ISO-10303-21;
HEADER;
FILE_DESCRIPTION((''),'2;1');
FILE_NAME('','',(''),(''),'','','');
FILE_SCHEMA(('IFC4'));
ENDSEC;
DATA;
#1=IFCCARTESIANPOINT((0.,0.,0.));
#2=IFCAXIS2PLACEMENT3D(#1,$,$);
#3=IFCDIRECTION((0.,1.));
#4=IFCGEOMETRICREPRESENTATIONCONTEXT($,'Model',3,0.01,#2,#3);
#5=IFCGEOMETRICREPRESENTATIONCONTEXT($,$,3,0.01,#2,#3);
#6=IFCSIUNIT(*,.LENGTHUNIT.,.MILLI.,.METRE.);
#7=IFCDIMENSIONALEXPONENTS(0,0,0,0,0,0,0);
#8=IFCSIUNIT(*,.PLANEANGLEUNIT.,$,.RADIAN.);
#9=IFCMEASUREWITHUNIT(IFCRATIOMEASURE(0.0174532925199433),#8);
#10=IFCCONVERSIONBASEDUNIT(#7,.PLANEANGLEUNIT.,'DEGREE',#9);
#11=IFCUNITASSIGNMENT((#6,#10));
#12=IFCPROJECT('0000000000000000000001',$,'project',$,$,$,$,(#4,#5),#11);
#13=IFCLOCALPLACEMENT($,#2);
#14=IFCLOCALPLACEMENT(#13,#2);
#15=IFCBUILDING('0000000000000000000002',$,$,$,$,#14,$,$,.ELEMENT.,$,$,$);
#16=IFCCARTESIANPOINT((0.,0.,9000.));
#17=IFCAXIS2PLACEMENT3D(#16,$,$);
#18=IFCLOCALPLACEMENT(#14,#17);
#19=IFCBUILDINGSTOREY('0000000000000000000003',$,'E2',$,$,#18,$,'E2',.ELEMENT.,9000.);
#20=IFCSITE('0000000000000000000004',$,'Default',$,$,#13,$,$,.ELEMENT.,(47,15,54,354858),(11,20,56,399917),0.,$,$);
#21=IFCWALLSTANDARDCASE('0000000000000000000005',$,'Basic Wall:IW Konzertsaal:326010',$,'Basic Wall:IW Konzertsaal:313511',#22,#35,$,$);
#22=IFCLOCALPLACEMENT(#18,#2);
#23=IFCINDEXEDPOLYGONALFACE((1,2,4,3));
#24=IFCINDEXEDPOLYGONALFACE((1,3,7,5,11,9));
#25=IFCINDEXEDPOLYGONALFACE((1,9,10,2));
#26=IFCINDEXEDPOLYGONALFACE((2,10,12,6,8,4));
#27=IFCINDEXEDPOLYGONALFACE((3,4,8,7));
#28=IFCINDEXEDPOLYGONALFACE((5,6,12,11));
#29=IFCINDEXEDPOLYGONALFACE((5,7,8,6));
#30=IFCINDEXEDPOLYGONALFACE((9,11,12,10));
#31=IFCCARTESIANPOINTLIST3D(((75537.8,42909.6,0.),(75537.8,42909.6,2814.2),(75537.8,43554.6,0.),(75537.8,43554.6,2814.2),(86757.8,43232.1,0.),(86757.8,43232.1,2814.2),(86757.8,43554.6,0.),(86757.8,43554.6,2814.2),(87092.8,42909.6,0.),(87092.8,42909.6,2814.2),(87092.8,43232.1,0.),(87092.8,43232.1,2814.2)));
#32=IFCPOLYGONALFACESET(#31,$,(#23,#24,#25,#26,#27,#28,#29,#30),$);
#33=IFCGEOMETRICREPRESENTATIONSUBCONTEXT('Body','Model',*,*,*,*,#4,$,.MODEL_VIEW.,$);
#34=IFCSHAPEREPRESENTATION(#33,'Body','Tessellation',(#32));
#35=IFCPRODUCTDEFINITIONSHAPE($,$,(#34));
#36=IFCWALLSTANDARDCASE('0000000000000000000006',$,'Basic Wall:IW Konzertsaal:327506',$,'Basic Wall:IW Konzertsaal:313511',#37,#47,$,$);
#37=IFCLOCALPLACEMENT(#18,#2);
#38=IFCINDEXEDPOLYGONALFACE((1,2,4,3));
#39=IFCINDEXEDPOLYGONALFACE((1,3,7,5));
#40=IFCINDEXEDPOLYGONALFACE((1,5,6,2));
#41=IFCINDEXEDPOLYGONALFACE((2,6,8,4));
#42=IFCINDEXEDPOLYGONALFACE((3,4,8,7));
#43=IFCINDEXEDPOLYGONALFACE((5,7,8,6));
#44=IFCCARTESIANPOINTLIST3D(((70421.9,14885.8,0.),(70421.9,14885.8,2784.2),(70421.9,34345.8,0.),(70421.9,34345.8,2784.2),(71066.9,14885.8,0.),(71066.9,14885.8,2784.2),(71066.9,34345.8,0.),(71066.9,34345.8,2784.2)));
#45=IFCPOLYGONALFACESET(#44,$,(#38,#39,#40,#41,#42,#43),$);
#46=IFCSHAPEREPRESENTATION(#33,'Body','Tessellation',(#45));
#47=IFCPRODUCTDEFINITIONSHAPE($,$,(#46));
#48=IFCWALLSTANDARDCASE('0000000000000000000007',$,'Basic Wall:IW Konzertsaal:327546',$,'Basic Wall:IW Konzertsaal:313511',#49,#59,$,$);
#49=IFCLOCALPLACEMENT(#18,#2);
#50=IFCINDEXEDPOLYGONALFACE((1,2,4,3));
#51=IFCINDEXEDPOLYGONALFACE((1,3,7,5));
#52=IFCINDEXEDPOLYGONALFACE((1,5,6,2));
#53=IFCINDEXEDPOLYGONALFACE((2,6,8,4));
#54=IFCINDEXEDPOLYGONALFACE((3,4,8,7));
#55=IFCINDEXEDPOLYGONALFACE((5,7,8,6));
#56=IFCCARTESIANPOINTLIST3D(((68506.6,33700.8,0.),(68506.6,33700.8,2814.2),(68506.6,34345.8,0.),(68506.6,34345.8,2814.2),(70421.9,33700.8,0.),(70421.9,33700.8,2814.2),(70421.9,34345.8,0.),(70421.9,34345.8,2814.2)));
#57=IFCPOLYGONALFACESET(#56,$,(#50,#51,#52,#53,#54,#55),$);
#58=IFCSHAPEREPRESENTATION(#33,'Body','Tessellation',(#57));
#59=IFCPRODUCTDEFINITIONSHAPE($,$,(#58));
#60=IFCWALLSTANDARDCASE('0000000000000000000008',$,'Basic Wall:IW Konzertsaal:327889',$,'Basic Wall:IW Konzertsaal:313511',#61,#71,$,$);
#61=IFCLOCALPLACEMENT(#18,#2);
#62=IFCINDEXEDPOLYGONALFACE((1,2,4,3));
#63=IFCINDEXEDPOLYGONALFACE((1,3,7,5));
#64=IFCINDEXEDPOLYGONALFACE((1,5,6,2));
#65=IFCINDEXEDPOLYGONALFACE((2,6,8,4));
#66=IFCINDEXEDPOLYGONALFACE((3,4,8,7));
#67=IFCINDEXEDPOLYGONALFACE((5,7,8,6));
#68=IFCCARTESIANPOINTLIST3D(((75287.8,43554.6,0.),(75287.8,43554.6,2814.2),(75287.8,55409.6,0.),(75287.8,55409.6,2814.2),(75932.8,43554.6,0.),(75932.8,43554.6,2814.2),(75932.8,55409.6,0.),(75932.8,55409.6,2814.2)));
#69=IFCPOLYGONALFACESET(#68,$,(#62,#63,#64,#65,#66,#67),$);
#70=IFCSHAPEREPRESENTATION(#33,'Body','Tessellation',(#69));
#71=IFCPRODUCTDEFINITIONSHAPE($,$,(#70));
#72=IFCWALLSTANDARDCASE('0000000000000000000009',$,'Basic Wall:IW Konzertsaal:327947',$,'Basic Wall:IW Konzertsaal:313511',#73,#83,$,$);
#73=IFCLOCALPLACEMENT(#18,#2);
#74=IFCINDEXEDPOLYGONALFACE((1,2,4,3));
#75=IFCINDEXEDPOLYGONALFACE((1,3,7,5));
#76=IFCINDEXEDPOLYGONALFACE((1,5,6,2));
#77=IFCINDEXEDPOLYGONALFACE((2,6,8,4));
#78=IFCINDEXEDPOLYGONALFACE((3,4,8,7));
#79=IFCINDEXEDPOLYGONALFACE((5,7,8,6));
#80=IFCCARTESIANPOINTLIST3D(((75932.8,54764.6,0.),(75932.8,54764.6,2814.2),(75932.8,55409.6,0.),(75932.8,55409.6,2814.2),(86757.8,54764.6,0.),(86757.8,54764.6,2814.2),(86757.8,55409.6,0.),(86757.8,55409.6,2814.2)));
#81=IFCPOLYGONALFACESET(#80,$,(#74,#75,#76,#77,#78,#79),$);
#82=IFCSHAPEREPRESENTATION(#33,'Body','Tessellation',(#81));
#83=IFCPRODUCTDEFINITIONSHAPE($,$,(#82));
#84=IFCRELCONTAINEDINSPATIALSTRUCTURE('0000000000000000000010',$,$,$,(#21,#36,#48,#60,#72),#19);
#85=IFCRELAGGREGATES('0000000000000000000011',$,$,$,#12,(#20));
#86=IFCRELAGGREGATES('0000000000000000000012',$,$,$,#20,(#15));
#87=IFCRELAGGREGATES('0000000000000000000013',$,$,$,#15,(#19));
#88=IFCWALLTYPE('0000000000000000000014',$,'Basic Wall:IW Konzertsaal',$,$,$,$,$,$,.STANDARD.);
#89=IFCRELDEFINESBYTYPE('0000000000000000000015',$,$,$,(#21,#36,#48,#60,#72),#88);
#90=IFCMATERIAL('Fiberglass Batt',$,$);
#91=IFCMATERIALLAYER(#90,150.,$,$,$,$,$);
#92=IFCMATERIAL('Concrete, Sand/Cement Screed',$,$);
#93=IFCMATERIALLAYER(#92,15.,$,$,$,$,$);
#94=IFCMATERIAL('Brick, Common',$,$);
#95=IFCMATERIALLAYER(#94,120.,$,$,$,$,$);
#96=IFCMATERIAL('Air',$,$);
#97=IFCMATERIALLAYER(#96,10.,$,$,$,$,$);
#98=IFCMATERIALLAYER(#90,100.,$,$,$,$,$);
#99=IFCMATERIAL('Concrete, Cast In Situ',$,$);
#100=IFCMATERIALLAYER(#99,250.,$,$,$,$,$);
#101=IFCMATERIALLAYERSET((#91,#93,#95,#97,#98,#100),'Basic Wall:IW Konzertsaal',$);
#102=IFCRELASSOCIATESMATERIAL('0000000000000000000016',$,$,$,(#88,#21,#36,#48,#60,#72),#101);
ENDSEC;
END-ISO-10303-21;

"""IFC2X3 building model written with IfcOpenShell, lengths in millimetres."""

from ifc_helpers import new_model, entity, si_unit, converted_unit, direction, frame, frame_2d, origin, place, context, subcontext, project, spatial, polyline, rectangle, outline, extrude, clip, bounded_halfspace, material, layer, layer_set, layer_usage, type_object, element, save


model = new_model("IFC2X3")

# Units and contexts
model_context = context("Model", 3, precision=0.01, world=origin(), true_north=direction((0.0, 1.0)))
context_of_model = context(None, 3, precision=0.01, world=origin(), true_north=direction((0.0, 1.0)))
body_context = subcontext(model_context, "Body", "Model", "MODEL_VIEW")
ifc_project = project(units=[si_unit("LENGTHUNIT", "METRE", prefix="MILLI"), converted_unit("PLANEANGLEUNIT", "DEGREE", entity("IfcRatioMeasure", 0.0174532925199433), si_unit("PLANEANGLEUNIT", "RADIAN"), dimensions=[0, 0, 0, 0, 0, 0, 0])], contexts=[model_context, context_of_model])

# Site, building, storey
site_placement = place(None, origin())
site = spatial("IfcSite", under=ifc_project, at=site_placement, Name="Default", CompositionType="ELEMENT", RefLatitude=(47, 15, 54, 354858), RefLongitude=(11, 20, 56, 399917), RefElevation=0.0)
building_placement = place(site_placement, origin())
building = spatial("IfcBuilding", under=site, at=building_placement, CompositionType="ELEMENT")
storey_placement = place(building_placement, frame((0.0, 0.0, 9000.0)))
storey = spatial("IfcBuildingStorey", under=building, at=storey_placement, Name="E2", LongName="E2", CompositionType="ELEMENT", Elevation=9000.0)

# Shared definitions
ifc_material_1 = material(Name="Concrete, Cast In Situ")

# Shared definitions
ifc_material_2 = material(Name="Fiberglass Batt")
ifc_material_3 = material(Name="Air")

# Walls
ifc_material_4 = material(Name="Concrete, Sand/Cement Screed")
ifc_material_5 = material(Name="Brick, Common")
ifc_layer_1 = layer(ifc_material_2, 150.0)
ifc_layer_2 = layer(ifc_material_4, 15.0)
ifc_layer_3 = layer(ifc_material_5, 120.0)
ifc_layer_4 = layer(ifc_material_3, 10.0)
ifc_layer_5 = layer(ifc_material_2, 100.0)
ifc_layer_6 = layer(ifc_material_1, 250.0)
ifc_layer_set_1 = layer_set([ifc_layer_1, ifc_layer_2, ifc_layer_3, ifc_layer_4, ifc_layer_5, ifc_layer_6], Name="Basic Wall:IW Konzertsaal")
ifc_layer_usage_1 = layer_usage(ifc_layer_set_1, "AXIS2", "POSITIVE", -322.5)
wall_type_1 = type_object("IfcWallType", Name="Basic Wall:IW Konzertsaal", PredefinedType="STANDARD", material=ifc_layer_set_1)
wall_1_placement = place(storey_placement, frame((87092.8, 43232.1, 0.0), z_axis=(0.0, 0.0, 1.0), x_axis=(-1.0, 0.0, 0.0)))
element("IfcWallStandardCase", 1, at=wall_1_placement, inside=storey, type_object=wall_type_1, material=ifc_layer_usage_1, Name="Basic Wall:IW Konzertsaal:326010", ObjectType="Basic Wall:IW Konzertsaal:313511", context=body_context, shape_type="Clipping", body=[
    clip(extrude(outline(polyline([(11555.0, -322.5), (11555.0, 322.5), (0.0, 322.5), (0.0, 0.0), (335.0, 0.0), (335.0, -322.5), (11160.0, -322.5), (11555.0, -322.5)])), origin(), (0.0, 0.0, 1.0), 2814.2), bounded_halfspace(frame((335.0, -322.5, 2814.2), z_axis=(0.0, 0.0, -1.0), x_axis=(-1.0, 0.0, 0.0)), True, frame((335.0, -322.5, 2814.2)), polyline([(0.0, 0.0), (10825.0, 0.0), (11220.0, 0.0), (11220.0, 645.0), (-335.0, 645.0), (-335.0, 322.5), (0.0, 322.5), (0.0, 0.0)]))),
])
ifc_layer_usage_2 = layer_usage(ifc_layer_set_1, "AXIS2", "NEGATIVE", 322.5)
wall_2_placement = place(storey_placement, frame((70744.4, 14885.8, 0.0), z_axis=(0.0, 0.0, 1.0), x_axis=(0.0, 1.0, 0.0)))
element("IfcWallStandardCase", 2, at=wall_2_placement, inside=storey, type_object=wall_type_1, material=ifc_layer_usage_2, Name="Basic Wall:IW Konzertsaal:327506", ObjectType="Basic Wall:IW Konzertsaal:313511", context=body_context, shape_type="Clipping", body=[
    clip(extrude(rectangle(XDim=19460.0, YDim=645.0, at=frame_2d((9730.0, 0.0), x_axis=(-1.0, 0.0))), origin(), (0.0, 0.0, 1.0), 2784.2), bounded_halfspace(frame((0.0, -322.5, 2784.2), z_axis=(0.0, 0.0, -1.0), x_axis=(0.0, -1.0, 0.0)), True, frame((0.0, -322.5, 2784.2)), polyline([(0.0, 0.0), (1038.8, 0.0), (1038.8, 645.0), (0.0, 645.0), (0.0, 0.0)]))),
])
ifc_layer_usage_3 = layer_usage(ifc_layer_set_1, "AXIS2", "NEGATIVE", 322.5)
wall_3_placement = place(storey_placement, frame((70421.9, 34023.3, 0.0), z_axis=(0.0, 0.0, 1.0), x_axis=(-1.0, 0.0, 0.0)))
element("IfcWallStandardCase", 3, at=wall_3_placement, inside=storey, type_object=wall_type_1, material=ifc_layer_usage_3, Name="Basic Wall:IW Konzertsaal:327546", ObjectType="Basic Wall:IW Konzertsaal:313511", context=body_context, shape_type="Clipping", body=[
    clip(extrude(rectangle(XDim=1915.3, YDim=645.0, at=frame_2d((957.7, 0.0), x_axis=(-1.0, 0.0))), origin(), (0.0, 0.0, 1.0), 2814.2), bounded_halfspace(frame((0.0, -322.5, 2814.2), z_axis=(0.0, 0.0, -1.0), x_axis=(-1.0, 0.0, 0.0)), True, frame((0.0, -322.5, 2814.2)), polyline([(0.0, 0.0), (1270.3, 0.0), (1915.3, 0.0), (1915.3, 645.0), (0.0, 645.0), (0.0, 0.0)]))),
])
ifc_layer_usage_4 = layer_usage(ifc_layer_set_1, "AXIS2", "POSITIVE", -322.5)
wall_4_placement = place(storey_placement, frame((75610.3, 43554.6, 0.0), z_axis=(0.0, 0.0, 1.0), x_axis=(0.0, 1.0, 0.0)))
element("IfcWallStandardCase", 4, at=wall_4_placement, inside=storey, type_object=wall_type_1, material=ifc_layer_usage_4, Name="Basic Wall:IW Konzertsaal:327889", ObjectType="Basic Wall:IW Konzertsaal:313511", context=body_context, shape_type="Clipping", body=[
    clip(extrude(rectangle(XDim=11855.0, YDim=645.0, at=frame_2d((5927.5, 0.0), x_axis=(-1.0, 0.0))), origin(), (0.0, 0.0, 1.0), 2814.2), bounded_halfspace(frame((0.0, -322.5, 2814.2), z_axis=(0.0, 0.0, -1.0), x_axis=(0.0, -1.0, 0.0)), True, frame((0.0, -322.5, 2814.2)), polyline([(0.0, 0.0), (11210.0, 0.0), (11855.0, 0.0), (11855.0, 645.0), (0.0, 645.0), (0.0, 395.0), (0.0, 0.0)]))),
])
ifc_layer_usage_5 = layer_usage(ifc_layer_set_1, "AXIS2", "POSITIVE", -322.5)
wall_5_placement = place(storey_placement, frame((75932.8, 55087.1, 0.0)))
element("IfcWallStandardCase", 5, at=wall_5_placement, inside=storey, type_object=wall_type_1, material=ifc_layer_usage_5, Name="Basic Wall:IW Konzertsaal:327947", ObjectType="Basic Wall:IW Konzertsaal:313511", context=body_context, shape_type="Clipping", body=[
    clip(extrude(rectangle(XDim=10825.0, YDim=645.0, at=frame_2d((5412.5, 0.0), x_axis=(-1.0, 0.0))), origin(), (0.0, 0.0, 1.0), 2814.2), bounded_halfspace(frame((0.0, -322.5, 2814.2), z_axis=(0.0, 0.0, -1.0), x_axis=(1.0, 0.0, 0.0)), True, frame((0.0, -322.5, 2814.2)), polyline([(0.0, 0.0), (10825.0, 0.0), (10825.0, 322.5), (10825.0, 645.0), (0.0, 645.0), (0.0, 0.0)]))),
])

save(model, "model.ifc")
